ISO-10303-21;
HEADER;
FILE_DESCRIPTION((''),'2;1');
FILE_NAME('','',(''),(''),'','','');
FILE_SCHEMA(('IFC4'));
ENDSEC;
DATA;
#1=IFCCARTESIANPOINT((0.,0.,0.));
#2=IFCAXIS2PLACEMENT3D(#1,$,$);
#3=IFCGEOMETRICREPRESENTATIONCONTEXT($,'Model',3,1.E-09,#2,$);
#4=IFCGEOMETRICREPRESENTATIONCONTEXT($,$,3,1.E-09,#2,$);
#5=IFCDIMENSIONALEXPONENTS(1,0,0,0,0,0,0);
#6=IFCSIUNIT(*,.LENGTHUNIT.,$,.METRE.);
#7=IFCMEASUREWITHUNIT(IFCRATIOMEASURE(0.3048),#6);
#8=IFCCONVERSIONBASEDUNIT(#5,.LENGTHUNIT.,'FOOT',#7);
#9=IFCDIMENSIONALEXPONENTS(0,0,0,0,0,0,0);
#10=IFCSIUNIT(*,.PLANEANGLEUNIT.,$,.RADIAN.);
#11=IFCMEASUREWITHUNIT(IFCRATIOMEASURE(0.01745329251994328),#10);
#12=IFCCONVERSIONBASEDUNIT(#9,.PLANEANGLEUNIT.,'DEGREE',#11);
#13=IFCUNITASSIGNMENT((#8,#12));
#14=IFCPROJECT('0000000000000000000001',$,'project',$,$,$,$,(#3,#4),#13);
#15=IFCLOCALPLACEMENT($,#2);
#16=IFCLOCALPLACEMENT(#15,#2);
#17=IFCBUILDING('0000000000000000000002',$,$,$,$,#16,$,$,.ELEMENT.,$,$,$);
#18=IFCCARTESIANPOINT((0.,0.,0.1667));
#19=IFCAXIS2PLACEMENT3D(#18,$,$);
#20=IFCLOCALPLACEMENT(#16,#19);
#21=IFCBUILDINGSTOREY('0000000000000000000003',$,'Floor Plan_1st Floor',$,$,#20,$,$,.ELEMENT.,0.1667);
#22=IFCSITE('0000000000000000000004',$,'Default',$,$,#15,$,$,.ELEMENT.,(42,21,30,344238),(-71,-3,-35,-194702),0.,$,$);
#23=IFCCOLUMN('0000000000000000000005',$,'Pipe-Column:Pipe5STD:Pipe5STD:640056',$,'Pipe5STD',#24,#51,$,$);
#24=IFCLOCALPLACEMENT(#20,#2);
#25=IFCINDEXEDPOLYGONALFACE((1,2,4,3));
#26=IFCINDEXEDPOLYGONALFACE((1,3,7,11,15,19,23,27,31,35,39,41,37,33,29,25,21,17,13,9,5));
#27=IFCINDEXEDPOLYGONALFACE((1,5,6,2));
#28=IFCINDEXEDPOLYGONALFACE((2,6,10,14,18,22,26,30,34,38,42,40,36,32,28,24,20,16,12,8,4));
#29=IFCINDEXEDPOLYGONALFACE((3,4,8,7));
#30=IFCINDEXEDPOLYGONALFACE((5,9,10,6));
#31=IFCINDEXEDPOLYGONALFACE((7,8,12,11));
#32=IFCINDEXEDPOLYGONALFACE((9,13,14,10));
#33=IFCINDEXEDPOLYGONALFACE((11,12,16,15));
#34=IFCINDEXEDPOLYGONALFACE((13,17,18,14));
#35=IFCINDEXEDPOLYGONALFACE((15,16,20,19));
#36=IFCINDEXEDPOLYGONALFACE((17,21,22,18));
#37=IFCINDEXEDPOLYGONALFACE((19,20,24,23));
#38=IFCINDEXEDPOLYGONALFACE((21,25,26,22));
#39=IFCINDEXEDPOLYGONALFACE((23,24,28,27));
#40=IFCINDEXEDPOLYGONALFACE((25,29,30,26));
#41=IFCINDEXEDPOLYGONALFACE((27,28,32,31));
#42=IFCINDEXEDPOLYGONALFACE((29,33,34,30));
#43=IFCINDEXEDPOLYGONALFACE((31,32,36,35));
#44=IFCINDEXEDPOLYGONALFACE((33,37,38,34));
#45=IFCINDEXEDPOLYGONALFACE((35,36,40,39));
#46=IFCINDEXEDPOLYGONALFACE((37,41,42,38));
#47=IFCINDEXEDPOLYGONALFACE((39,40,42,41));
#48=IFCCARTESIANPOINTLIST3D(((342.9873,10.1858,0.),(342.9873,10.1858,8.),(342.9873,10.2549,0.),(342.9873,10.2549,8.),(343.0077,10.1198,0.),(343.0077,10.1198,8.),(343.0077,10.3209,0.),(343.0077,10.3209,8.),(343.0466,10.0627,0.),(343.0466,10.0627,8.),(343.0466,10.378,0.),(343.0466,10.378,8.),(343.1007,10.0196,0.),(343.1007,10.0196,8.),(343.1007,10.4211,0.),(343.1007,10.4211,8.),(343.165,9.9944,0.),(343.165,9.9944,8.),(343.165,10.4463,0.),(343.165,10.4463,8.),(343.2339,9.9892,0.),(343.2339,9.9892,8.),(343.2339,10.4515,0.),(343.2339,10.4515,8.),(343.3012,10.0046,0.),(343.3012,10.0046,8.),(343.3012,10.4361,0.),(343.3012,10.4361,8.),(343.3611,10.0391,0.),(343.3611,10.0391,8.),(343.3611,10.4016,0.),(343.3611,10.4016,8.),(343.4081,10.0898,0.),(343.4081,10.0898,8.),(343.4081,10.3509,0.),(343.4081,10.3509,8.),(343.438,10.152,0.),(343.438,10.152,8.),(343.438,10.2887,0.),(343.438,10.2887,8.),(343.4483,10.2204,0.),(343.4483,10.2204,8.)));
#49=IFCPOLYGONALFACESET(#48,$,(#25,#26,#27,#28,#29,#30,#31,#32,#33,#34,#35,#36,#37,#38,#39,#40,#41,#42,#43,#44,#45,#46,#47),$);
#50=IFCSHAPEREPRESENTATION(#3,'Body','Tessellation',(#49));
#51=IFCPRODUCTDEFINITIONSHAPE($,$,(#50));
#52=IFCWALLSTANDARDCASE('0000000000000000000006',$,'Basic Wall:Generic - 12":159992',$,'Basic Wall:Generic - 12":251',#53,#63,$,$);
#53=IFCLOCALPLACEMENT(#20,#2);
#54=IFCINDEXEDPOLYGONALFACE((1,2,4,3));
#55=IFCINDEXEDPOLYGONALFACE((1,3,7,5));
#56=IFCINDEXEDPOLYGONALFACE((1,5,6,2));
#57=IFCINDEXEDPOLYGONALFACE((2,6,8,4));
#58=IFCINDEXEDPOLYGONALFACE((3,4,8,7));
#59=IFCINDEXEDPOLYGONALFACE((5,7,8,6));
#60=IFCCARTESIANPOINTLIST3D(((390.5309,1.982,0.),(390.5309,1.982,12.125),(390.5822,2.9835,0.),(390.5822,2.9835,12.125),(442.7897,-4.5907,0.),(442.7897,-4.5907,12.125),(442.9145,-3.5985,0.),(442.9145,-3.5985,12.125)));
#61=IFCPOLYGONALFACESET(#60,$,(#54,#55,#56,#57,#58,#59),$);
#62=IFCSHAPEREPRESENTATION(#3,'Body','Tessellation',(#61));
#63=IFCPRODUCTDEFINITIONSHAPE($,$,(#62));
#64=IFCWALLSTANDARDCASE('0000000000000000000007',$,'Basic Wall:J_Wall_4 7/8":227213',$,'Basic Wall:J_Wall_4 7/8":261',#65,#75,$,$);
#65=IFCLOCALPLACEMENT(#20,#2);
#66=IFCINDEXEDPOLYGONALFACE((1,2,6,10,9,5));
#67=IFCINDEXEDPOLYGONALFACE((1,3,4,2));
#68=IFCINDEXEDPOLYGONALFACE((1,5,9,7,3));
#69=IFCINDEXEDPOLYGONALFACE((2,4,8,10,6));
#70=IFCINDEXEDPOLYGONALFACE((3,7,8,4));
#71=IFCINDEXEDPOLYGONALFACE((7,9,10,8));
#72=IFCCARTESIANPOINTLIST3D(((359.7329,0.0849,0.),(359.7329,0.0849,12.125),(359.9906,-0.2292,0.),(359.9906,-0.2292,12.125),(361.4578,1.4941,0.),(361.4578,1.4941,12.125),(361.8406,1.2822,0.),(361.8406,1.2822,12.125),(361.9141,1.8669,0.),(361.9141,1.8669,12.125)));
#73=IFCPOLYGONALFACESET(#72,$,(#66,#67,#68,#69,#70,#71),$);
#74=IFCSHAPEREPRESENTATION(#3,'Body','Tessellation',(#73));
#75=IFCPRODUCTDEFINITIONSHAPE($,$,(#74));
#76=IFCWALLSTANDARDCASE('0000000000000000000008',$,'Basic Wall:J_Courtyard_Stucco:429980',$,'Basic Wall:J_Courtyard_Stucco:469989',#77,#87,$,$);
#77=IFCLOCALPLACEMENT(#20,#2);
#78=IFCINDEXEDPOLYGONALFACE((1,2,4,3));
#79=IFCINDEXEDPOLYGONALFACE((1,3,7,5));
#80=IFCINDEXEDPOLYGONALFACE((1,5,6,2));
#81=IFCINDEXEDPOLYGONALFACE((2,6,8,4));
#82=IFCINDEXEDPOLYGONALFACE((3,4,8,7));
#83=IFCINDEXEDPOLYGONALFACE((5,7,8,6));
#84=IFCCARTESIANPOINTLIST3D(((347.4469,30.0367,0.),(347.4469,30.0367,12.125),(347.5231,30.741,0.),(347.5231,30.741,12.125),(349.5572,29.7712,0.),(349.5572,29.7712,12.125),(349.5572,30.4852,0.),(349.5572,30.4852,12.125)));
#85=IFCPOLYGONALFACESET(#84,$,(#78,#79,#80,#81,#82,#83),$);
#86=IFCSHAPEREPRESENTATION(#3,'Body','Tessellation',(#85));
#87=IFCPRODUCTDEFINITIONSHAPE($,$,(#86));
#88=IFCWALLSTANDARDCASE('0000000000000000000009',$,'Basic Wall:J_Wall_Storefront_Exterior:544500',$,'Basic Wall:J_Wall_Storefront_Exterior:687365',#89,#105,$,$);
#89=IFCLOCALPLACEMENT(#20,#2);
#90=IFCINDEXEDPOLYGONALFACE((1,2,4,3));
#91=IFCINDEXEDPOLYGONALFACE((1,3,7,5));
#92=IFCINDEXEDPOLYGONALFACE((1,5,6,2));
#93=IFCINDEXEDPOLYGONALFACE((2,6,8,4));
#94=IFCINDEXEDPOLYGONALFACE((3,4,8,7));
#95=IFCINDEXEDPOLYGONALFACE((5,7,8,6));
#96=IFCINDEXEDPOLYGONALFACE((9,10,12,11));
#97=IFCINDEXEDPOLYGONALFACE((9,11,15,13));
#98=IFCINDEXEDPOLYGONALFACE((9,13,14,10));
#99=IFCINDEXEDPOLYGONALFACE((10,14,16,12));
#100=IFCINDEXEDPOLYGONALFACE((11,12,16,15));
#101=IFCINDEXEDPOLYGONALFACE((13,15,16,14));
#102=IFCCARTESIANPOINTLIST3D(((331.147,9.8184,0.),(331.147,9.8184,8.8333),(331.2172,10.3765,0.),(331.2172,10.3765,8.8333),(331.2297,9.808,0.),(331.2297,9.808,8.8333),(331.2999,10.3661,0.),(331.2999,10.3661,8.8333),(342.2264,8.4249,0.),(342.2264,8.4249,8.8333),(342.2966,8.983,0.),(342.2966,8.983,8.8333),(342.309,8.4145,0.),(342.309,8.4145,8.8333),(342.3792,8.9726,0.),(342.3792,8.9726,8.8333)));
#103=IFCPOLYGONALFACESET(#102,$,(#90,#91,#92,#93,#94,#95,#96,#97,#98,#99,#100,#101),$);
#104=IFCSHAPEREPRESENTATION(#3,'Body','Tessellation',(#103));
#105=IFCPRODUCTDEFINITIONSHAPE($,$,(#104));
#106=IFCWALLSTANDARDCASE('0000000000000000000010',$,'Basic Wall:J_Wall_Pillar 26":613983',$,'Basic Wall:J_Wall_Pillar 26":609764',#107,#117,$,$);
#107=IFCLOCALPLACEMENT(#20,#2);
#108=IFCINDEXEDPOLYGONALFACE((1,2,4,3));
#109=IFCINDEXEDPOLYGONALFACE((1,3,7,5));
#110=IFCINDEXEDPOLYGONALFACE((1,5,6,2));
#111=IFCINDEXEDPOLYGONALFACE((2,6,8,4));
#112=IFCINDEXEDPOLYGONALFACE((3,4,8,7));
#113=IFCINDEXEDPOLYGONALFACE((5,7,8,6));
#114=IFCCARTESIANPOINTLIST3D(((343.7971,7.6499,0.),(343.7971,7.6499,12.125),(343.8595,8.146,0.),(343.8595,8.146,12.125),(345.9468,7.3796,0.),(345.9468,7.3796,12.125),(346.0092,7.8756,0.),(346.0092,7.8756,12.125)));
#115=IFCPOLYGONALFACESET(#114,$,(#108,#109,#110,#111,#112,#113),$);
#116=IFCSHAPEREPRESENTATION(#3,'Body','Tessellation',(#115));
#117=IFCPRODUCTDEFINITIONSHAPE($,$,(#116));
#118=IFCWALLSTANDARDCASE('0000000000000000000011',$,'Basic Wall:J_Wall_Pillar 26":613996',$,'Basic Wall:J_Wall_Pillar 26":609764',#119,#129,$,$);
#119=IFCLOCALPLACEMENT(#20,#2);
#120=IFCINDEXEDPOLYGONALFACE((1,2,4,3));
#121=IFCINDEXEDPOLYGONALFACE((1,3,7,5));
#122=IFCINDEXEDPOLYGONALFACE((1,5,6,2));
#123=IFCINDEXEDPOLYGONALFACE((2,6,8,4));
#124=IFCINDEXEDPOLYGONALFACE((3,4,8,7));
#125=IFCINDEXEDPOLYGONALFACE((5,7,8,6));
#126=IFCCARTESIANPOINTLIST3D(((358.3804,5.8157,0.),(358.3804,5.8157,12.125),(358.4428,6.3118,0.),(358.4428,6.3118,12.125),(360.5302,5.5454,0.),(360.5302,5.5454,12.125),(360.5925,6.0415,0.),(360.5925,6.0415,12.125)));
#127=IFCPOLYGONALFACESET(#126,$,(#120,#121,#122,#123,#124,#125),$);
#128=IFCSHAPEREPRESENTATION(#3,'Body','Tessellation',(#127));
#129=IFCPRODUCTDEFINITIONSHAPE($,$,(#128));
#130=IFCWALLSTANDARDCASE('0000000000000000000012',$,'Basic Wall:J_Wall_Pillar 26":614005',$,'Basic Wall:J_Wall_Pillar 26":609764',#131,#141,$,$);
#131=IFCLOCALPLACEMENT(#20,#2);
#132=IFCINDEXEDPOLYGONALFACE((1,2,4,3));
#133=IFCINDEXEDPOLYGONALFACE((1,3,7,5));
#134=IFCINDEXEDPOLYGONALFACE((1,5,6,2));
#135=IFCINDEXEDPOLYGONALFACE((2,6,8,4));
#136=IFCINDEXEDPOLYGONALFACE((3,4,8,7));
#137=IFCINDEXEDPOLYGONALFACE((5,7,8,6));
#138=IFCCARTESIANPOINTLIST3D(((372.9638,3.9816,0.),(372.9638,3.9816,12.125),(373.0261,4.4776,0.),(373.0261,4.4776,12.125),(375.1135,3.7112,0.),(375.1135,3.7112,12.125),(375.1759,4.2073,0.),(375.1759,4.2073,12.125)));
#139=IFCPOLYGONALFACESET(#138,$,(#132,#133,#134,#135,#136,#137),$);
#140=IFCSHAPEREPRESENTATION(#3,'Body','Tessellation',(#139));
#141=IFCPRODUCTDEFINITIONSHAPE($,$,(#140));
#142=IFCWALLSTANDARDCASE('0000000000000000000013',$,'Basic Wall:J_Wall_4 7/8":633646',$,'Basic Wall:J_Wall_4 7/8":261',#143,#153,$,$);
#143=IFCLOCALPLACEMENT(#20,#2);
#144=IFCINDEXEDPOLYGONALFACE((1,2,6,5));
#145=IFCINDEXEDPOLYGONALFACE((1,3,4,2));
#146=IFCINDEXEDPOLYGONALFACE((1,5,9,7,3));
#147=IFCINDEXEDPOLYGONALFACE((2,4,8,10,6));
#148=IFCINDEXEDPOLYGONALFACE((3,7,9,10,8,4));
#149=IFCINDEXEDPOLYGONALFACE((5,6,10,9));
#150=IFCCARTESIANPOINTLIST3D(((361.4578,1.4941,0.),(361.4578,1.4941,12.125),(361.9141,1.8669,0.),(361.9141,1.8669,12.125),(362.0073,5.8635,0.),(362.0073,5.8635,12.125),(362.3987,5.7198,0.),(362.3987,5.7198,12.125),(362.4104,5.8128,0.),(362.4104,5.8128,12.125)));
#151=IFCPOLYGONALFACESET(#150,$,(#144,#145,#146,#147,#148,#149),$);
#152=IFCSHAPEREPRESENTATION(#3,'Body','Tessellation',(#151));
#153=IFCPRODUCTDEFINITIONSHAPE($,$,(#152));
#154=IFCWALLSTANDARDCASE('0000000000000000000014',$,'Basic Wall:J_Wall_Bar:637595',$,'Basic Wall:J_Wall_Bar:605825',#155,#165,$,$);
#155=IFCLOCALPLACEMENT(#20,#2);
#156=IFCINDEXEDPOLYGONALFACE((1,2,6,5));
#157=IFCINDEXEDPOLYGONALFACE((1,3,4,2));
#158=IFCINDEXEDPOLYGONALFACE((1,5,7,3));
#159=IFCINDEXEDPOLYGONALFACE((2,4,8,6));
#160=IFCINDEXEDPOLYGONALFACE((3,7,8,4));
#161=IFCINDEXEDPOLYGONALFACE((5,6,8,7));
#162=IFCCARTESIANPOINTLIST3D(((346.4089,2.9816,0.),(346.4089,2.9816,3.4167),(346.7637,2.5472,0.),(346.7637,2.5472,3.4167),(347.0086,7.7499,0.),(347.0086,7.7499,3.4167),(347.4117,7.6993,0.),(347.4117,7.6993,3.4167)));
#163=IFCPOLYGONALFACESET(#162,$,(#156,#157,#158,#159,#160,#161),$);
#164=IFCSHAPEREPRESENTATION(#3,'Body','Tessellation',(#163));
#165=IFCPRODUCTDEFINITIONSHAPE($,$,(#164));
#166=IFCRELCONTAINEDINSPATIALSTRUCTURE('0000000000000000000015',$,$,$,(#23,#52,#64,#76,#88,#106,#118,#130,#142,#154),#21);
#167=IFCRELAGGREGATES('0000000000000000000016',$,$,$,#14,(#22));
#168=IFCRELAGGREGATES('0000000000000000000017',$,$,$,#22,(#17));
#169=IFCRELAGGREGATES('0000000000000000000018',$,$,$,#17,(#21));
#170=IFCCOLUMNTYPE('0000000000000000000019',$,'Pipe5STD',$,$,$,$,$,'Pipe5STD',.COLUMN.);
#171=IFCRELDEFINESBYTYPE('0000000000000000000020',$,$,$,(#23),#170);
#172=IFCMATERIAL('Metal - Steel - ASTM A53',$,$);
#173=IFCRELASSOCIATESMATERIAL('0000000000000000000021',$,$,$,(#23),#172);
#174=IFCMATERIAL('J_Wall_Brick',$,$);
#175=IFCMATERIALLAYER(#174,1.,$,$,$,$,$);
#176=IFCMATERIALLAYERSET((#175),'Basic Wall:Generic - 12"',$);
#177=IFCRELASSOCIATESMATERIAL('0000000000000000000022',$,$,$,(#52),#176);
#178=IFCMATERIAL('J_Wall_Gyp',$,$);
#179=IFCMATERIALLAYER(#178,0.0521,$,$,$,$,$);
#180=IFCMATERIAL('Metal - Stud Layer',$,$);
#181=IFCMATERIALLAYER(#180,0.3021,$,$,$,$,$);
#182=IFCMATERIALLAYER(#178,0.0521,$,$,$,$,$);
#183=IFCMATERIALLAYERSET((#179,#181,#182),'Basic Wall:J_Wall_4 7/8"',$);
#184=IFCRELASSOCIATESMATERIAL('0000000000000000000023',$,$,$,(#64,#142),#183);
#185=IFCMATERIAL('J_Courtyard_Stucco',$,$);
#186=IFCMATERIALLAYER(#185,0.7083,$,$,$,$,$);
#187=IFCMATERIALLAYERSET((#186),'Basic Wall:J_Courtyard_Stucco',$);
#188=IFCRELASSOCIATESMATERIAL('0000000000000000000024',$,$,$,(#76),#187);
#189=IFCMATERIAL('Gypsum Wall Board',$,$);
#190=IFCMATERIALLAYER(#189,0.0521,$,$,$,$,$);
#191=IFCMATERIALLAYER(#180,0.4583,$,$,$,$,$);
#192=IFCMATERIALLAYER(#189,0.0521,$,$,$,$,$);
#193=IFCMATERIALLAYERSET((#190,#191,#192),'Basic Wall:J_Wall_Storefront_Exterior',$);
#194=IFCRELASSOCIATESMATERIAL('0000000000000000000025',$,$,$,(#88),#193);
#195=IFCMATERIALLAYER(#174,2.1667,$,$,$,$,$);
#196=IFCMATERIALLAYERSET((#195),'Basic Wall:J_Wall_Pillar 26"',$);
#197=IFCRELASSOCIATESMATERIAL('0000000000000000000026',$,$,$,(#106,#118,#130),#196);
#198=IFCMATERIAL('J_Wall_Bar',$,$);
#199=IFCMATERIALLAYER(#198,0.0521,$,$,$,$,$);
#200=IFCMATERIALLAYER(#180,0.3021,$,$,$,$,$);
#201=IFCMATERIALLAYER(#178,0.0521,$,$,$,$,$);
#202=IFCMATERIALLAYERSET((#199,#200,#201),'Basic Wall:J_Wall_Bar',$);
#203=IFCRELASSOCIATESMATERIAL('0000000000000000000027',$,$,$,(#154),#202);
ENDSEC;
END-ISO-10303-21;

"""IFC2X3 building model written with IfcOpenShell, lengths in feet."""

from ifc_helpers import new_model, entity, si_unit, converted_unit, frame, frame_2d, origin, origin_2d_with_axis, place, context, project, spatial, polyline, rectangle, circle, outline, extrude, clip, halfspace, source, transform, mapped, material, layer, layer_set, layer_usage, type_object, type_shapes, element, save


model = new_model("IFC2X3")

# Units and contexts
model_context = context("Model", 3, precision=1e-09, world=origin())
context_of_model = context(None, 3, precision=1e-09, world=origin())
ifc_project = project(units=[converted_unit("LENGTHUNIT", "FOOT", entity("IfcRatioMeasure", 0.3048), si_unit("LENGTHUNIT", "METRE"), dimensions=[1, 0, 0, 0, 0, 0, 0]), converted_unit("PLANEANGLEUNIT", "DEGREE", entity("IfcRatioMeasure", 0.01745329251994328), si_unit("PLANEANGLEUNIT", "RADIAN"), dimensions=[0, 0, 0, 0, 0, 0, 0])], contexts=[model_context, context_of_model])

# Site, building, storey
site_placement = place(None, origin())
site = spatial("IfcSite", under=ifc_project, at=site_placement, Name="Default", CompositionType="ELEMENT", RefLatitude=(42, 21, 30, 344238), RefLongitude=(-71, -3, -35, -194702), RefElevation=0.0)
building_placement = place(site_placement, origin())
building = spatial("IfcBuilding", under=site, at=building_placement, CompositionType="ELEMENT")
storey_placement = place(building_placement, frame((0.0, 0.0, 0.1667)))
storey = spatial("IfcBuildingStorey", under=building, at=storey_placement, Name="Floor Plan_1st Floor", CompositionType="ELEMENT", Elevation=0.1667)

# Column
ifc_material_1 = material(Name="Metal - Steel - ASTM A53")
column_type = type_object("IfcColumnType", Name="Pipe5STD", ElementType="Pipe5STD", PredefinedType="COLUMN")
shared_shape_1 = source(origin(), model_context, "Body", "SweptSolid", [
    extrude(circle(Radius=0.2318, at=origin_2d_with_axis()), origin(), (0.0, 0.0, 1.0), 8.0),
])
type_shapes(column_type, [shared_shape_1])
column_placement = place(storey_placement, frame((343.2165, 10.2204, 0.0)))
element("IfcColumn", 1, at=column_placement, inside=storey, type_object=column_type, material=ifc_material_1, Name="Pipe-Column:Pipe5STD:Pipe5STD:640056", ObjectType="Pipe5STD", context=model_context, shape_type="MappedRepresentation", body=[
    mapped(shared_shape_1, transform((0.0, 0.0, 0.0), scale=1.0)),
])

# Walls
ifc_material_2 = material(Name="J_Wall_Brick")
ifc_layer_1 = layer(ifc_material_2, 1.0)
ifc_layer_set_1 = layer_set([ifc_layer_1], Name="Basic Wall:Generic - 12\"")
ifc_layer_usage_1 = layer_usage(ifc_layer_set_1, "AXIS2", "NEGATIVE", 0.5)
wall_1_placement = place(storey_placement, frame((390.5198, 2.4874, 0.0), z_axis=(0.0, 0.0, 1.0), x_axis=(0.992183, -0.12479, 0.0)))
element("IfcWallStandardCase", 2, at=wall_1_placement, inside=storey, material=ifc_layer_usage_1, Name="Basic Wall:Generic - 12\":159992", ObjectType="Basic Wall:Generic - 12\":251", context=model_context, shape_type="SweptSolid", body=[
    extrude(outline(polyline([(52.7446, -0.5), (52.7446, 0.5), (0.0, 0.5), (0.0741, -0.5), (52.7446, -0.5)])), origin(), (0.0, 0.0, 1.0), 12.125),
])
ifc_material_3 = material(Name="J_Wall_Gyp")
ifc_layer_2 = layer(ifc_material_3, 0.0521)
ifc_material_4 = material(Name="Metal - Stud Layer")
ifc_layer_3 = layer(ifc_material_4, 0.3021)
ifc_layer_4 = layer(ifc_material_3, 0.0521)
ifc_layer_set_2 = layer_set([ifc_layer_2, ifc_layer_3, ifc_layer_4], Name="Basic Wall:J_Wall_4 7/8\"")
ifc_layer_usage_2 = layer_usage(ifc_layer_set_2, "AXIS2", "NEGATIVE", 0.2031)
wall_2_placement = place(storey_placement, frame((359.8614, -0.0724, 0.0), z_axis=(0.0, 0.0, 1.0), x_axis=(0.774414, 0.63268, 0.0)))
element("IfcWallStandardCase", 3, at=wall_2_placement, inside=storey, material=ifc_layer_usage_2, Name="Basic Wall:J_Wall_4 7/8\":227213", ObjectType="Basic Wall:J_Wall_4 7/8\":261", context=model_context, shape_type="SweptSolid", body=[
    extrude(outline(polyline([(2.3898, -0.2031), (2.8166, 0.2031), (2.2273, 0.2031), (0.0, 0.2031), (0.0009, -0.2031), (2.3898, -0.2031)])), origin(), (0.0, 0.0, 1.0), 12.125),
])

# Shared definitions
ifc_material_5 = material(Name="J_Courtyard_Stucco")
ifc_layer_5 = layer(ifc_material_5, 0.7083)
ifc_layer_set_3 = layer_set([ifc_layer_5], Name="Basic Wall:J_Courtyard_Stucco")

# Wall
ifc_layer_usage_3 = layer_usage(ifc_layer_set_3, "AXIS2", "NEGATIVE", 0.3542)
wall_3_placement = place(storey_placement, frame((347.4789, 30.3896, 0.0), z_axis=(0.0, 0.0, 1.0), x_axis=(0.992183, -0.12479, 0.0)))
element("IfcWallStandardCase", 4, at=wall_3_placement, inside=storey, material=ifc_layer_usage_3, Name="Basic Wall:J_Courtyard_Stucco:429980", ObjectType="Basic Wall:J_Courtyard_Stucco:469989", context=model_context, shape_type="Clipping", body=[
    clip(extrude(outline(polyline([(2.1392, -0.3542), (2.0501, 0.3542), (0.0, 0.3542), (0.0123, -0.3542), (2.1392, -0.3542)])), origin(), (0.0, 0.0, 1.0), 12.125), halfspace(origin(), True)),
])

# Wall, opening
ifc_material_6 = material(Name="Gypsum Wall Board")
ifc_layer_6 = layer(ifc_material_6, 0.0521)
ifc_layer_7 = layer(ifc_material_4, 0.4583)
ifc_layer_8 = layer(ifc_material_6, 0.0521)
ifc_layer_set_4 = layer_set([ifc_layer_6, ifc_layer_7, ifc_layer_8], Name="Basic Wall:J_Wall_Storefront_Exterior")
ifc_layer_usage_4 = layer_usage(ifc_layer_set_4, "AXIS2", "NEGATIVE", 0.2812)
wall_4_placement = place(storey_placement, frame((342.3441, 8.6936, 0.0), z_axis=(0.0, 0.0, 1.0), x_axis=(-0.992183, 0.12479, 0.0)))
wall_4 = element("IfcWallStandardCase", 5, at=wall_4_placement, inside=storey, material=ifc_layer_usage_4, Name="Basic Wall:J_Wall_Storefront_Exterior:544500", ObjectType="Basic Wall:J_Wall_Storefront_Exterior:687365", context=model_context, shape_type="SweptSolid", body=[
    extrude(rectangle(XDim=11.25, YDim=0.5625, at=frame_2d((5.625, 0.0), x_axis=(-1.0, 0.0))), origin(), (0.0, 0.0, 1.0), 8.8333),
])
opening_1_placement = place(wall_4_placement, frame((0.0833, -0.2813, 0.0)))
element("IfcOpeningElement", 6, at=opening_1_placement, cuts=wall_4, ObjectType="Opening", context=model_context, shape_type="SweptSolid", body=[
    extrude(rectangle(XDim=8.8333, YDim=11.0833, at=frame_2d((4.4167, 5.5417), x_axis=(1.0, 0.0))), frame((0.0, 0.0, 0.0), z_axis=(0.0, 1.0, 0.0), x_axis=(0.0, 0.0, 1.0)), (0.0, 0.0, 1.0), 0.5625),
])

# Walls
ifc_layer_9 = layer(ifc_material_2, 2.1667)
ifc_layer_set_5 = layer_set([ifc_layer_9], Name="Basic Wall:J_Wall_Pillar 26\"")
ifc_layer_usage_5 = layer_usage(ifc_layer_set_5, "AXIS2", "NEGATIVE", 1.0833)
wall_5_placement = place(storey_placement, frame((344.872, 7.5147, 0.0), z_axis=(0.0, 0.0, 1.0), x_axis=(0.12479, 0.992183, 0.0)))
element("IfcWallStandardCase", 7, at=wall_5_placement, inside=storey, material=ifc_layer_usage_5, Name="Basic Wall:J_Wall_Pillar 26\":613983", ObjectType="Basic Wall:J_Wall_Pillar 26\":609764", context=model_context, shape_type="Clipping", body=[
    clip(extrude(rectangle(XDim=0.5, YDim=2.1667, at=frame_2d((0.25, 0.0), x_axis=(-1.0, 0.0))), origin(), (0.0, 0.0, 1.0), 12.125), halfspace(origin(), True)),
])
ifc_layer_usage_6 = layer_usage(ifc_layer_set_5, "AXIS2", "NEGATIVE", 1.0833)
wall_6_placement = place(storey_placement, frame((359.4553, 5.6806, 0.0), z_axis=(0.0, 0.0, 1.0), x_axis=(0.12479, 0.992183, 0.0)))
element("IfcWallStandardCase", 8, at=wall_6_placement, inside=storey, material=ifc_layer_usage_6, Name="Basic Wall:J_Wall_Pillar 26\":613996", ObjectType="Basic Wall:J_Wall_Pillar 26\":609764", context=model_context, shape_type="Clipping", body=[
    clip(extrude(rectangle(XDim=0.5, YDim=2.1667, at=frame_2d((0.25, 0.0), x_axis=(-1.0, 0.0))), origin(), (0.0, 0.0, 1.0), 12.125), halfspace(origin(), True)),
])
ifc_layer_usage_7 = layer_usage(ifc_layer_set_5, "AXIS2", "NEGATIVE", 1.0833)
wall_7_placement = place(storey_placement, frame((374.0386, 3.8464, 0.0), z_axis=(0.0, 0.0, 1.0), x_axis=(0.12479, 0.992183, 0.0)))
element("IfcWallStandardCase", 9, at=wall_7_placement, inside=storey, material=ifc_layer_usage_7, Name="Basic Wall:J_Wall_Pillar 26\":614005", ObjectType="Basic Wall:J_Wall_Pillar 26\":609764", context=model_context, shape_type="Clipping", body=[
    clip(extrude(rectangle(XDim=0.5, YDim=2.1667, at=frame_2d((0.25, 0.0), x_axis=(-1.0, 0.0))), origin(), (0.0, 0.0, 1.0), 12.125), halfspace(origin(), True)),
])
ifc_layer_usage_8 = layer_usage(ifc_layer_set_2, "AXIS2", "NEGATIVE", 0.2031)
wall_8_placement = place(storey_placement, frame((362.2089, 5.8382, 0.0), z_axis=(0.0, 0.0, 1.0), x_axis=(-0.12479, -0.992183, 0.0)))
element("IfcWallStandardCase", 10, at=wall_8_placement, inside=storey, material=ifc_layer_usage_8, Name="Basic Wall:J_Wall_4 7/8\":633646", ObjectType="Basic Wall:J_Wall_4 7/8\":261", context=model_context, shape_type="SweptSolid", body=[
    extrude(outline(polyline([(4.4039, -0.2031), (3.977, 0.2031), (0.0937, 0.2031), (0.0, 0.2031), (0.0, -0.2031), (4.4039, -0.2031)])), origin(), (0.0, 0.0, 1.0), 12.125),
])
ifc_material_7 = material(Name="J_Wall_Bar")
ifc_layer_10 = layer(ifc_material_7, 0.0521)
ifc_layer_11 = layer(ifc_material_4, 0.3021)
ifc_layer_12 = layer(ifc_material_3, 0.0521)
ifc_layer_set_6 = layer_set([ifc_layer_10, ifc_layer_11, ifc_layer_12], Name="Basic Wall:J_Wall_Bar")
ifc_layer_usage_9 = layer_usage(ifc_layer_set_6, "AXIS2", "NEGATIVE", 0.2031)
wall_9_placement = place(storey_placement, frame((347.2102, 7.7246, 0.0), z_axis=(0.0, 0.0, 1.0), x_axis=(-0.12479, -0.992183, 0.0)))
element("IfcWallStandardCase", 11, at=wall_9_placement, inside=storey, material=ifc_layer_usage_9, Name="Basic Wall:J_Wall_Bar:637595", ObjectType="Basic Wall:J_Wall_Bar:605825", context=model_context, shape_type="SweptSolid", body=[
    extrude(outline(polyline([(4.8059, -0.2031), (5.1926, 0.2031), (0.0, 0.2031), (0.0, -0.2031), (4.8059, -0.2031)])), origin(), (0.0, 0.0, 1.0), 3.4167),
])

save(model, "model.ifc")
